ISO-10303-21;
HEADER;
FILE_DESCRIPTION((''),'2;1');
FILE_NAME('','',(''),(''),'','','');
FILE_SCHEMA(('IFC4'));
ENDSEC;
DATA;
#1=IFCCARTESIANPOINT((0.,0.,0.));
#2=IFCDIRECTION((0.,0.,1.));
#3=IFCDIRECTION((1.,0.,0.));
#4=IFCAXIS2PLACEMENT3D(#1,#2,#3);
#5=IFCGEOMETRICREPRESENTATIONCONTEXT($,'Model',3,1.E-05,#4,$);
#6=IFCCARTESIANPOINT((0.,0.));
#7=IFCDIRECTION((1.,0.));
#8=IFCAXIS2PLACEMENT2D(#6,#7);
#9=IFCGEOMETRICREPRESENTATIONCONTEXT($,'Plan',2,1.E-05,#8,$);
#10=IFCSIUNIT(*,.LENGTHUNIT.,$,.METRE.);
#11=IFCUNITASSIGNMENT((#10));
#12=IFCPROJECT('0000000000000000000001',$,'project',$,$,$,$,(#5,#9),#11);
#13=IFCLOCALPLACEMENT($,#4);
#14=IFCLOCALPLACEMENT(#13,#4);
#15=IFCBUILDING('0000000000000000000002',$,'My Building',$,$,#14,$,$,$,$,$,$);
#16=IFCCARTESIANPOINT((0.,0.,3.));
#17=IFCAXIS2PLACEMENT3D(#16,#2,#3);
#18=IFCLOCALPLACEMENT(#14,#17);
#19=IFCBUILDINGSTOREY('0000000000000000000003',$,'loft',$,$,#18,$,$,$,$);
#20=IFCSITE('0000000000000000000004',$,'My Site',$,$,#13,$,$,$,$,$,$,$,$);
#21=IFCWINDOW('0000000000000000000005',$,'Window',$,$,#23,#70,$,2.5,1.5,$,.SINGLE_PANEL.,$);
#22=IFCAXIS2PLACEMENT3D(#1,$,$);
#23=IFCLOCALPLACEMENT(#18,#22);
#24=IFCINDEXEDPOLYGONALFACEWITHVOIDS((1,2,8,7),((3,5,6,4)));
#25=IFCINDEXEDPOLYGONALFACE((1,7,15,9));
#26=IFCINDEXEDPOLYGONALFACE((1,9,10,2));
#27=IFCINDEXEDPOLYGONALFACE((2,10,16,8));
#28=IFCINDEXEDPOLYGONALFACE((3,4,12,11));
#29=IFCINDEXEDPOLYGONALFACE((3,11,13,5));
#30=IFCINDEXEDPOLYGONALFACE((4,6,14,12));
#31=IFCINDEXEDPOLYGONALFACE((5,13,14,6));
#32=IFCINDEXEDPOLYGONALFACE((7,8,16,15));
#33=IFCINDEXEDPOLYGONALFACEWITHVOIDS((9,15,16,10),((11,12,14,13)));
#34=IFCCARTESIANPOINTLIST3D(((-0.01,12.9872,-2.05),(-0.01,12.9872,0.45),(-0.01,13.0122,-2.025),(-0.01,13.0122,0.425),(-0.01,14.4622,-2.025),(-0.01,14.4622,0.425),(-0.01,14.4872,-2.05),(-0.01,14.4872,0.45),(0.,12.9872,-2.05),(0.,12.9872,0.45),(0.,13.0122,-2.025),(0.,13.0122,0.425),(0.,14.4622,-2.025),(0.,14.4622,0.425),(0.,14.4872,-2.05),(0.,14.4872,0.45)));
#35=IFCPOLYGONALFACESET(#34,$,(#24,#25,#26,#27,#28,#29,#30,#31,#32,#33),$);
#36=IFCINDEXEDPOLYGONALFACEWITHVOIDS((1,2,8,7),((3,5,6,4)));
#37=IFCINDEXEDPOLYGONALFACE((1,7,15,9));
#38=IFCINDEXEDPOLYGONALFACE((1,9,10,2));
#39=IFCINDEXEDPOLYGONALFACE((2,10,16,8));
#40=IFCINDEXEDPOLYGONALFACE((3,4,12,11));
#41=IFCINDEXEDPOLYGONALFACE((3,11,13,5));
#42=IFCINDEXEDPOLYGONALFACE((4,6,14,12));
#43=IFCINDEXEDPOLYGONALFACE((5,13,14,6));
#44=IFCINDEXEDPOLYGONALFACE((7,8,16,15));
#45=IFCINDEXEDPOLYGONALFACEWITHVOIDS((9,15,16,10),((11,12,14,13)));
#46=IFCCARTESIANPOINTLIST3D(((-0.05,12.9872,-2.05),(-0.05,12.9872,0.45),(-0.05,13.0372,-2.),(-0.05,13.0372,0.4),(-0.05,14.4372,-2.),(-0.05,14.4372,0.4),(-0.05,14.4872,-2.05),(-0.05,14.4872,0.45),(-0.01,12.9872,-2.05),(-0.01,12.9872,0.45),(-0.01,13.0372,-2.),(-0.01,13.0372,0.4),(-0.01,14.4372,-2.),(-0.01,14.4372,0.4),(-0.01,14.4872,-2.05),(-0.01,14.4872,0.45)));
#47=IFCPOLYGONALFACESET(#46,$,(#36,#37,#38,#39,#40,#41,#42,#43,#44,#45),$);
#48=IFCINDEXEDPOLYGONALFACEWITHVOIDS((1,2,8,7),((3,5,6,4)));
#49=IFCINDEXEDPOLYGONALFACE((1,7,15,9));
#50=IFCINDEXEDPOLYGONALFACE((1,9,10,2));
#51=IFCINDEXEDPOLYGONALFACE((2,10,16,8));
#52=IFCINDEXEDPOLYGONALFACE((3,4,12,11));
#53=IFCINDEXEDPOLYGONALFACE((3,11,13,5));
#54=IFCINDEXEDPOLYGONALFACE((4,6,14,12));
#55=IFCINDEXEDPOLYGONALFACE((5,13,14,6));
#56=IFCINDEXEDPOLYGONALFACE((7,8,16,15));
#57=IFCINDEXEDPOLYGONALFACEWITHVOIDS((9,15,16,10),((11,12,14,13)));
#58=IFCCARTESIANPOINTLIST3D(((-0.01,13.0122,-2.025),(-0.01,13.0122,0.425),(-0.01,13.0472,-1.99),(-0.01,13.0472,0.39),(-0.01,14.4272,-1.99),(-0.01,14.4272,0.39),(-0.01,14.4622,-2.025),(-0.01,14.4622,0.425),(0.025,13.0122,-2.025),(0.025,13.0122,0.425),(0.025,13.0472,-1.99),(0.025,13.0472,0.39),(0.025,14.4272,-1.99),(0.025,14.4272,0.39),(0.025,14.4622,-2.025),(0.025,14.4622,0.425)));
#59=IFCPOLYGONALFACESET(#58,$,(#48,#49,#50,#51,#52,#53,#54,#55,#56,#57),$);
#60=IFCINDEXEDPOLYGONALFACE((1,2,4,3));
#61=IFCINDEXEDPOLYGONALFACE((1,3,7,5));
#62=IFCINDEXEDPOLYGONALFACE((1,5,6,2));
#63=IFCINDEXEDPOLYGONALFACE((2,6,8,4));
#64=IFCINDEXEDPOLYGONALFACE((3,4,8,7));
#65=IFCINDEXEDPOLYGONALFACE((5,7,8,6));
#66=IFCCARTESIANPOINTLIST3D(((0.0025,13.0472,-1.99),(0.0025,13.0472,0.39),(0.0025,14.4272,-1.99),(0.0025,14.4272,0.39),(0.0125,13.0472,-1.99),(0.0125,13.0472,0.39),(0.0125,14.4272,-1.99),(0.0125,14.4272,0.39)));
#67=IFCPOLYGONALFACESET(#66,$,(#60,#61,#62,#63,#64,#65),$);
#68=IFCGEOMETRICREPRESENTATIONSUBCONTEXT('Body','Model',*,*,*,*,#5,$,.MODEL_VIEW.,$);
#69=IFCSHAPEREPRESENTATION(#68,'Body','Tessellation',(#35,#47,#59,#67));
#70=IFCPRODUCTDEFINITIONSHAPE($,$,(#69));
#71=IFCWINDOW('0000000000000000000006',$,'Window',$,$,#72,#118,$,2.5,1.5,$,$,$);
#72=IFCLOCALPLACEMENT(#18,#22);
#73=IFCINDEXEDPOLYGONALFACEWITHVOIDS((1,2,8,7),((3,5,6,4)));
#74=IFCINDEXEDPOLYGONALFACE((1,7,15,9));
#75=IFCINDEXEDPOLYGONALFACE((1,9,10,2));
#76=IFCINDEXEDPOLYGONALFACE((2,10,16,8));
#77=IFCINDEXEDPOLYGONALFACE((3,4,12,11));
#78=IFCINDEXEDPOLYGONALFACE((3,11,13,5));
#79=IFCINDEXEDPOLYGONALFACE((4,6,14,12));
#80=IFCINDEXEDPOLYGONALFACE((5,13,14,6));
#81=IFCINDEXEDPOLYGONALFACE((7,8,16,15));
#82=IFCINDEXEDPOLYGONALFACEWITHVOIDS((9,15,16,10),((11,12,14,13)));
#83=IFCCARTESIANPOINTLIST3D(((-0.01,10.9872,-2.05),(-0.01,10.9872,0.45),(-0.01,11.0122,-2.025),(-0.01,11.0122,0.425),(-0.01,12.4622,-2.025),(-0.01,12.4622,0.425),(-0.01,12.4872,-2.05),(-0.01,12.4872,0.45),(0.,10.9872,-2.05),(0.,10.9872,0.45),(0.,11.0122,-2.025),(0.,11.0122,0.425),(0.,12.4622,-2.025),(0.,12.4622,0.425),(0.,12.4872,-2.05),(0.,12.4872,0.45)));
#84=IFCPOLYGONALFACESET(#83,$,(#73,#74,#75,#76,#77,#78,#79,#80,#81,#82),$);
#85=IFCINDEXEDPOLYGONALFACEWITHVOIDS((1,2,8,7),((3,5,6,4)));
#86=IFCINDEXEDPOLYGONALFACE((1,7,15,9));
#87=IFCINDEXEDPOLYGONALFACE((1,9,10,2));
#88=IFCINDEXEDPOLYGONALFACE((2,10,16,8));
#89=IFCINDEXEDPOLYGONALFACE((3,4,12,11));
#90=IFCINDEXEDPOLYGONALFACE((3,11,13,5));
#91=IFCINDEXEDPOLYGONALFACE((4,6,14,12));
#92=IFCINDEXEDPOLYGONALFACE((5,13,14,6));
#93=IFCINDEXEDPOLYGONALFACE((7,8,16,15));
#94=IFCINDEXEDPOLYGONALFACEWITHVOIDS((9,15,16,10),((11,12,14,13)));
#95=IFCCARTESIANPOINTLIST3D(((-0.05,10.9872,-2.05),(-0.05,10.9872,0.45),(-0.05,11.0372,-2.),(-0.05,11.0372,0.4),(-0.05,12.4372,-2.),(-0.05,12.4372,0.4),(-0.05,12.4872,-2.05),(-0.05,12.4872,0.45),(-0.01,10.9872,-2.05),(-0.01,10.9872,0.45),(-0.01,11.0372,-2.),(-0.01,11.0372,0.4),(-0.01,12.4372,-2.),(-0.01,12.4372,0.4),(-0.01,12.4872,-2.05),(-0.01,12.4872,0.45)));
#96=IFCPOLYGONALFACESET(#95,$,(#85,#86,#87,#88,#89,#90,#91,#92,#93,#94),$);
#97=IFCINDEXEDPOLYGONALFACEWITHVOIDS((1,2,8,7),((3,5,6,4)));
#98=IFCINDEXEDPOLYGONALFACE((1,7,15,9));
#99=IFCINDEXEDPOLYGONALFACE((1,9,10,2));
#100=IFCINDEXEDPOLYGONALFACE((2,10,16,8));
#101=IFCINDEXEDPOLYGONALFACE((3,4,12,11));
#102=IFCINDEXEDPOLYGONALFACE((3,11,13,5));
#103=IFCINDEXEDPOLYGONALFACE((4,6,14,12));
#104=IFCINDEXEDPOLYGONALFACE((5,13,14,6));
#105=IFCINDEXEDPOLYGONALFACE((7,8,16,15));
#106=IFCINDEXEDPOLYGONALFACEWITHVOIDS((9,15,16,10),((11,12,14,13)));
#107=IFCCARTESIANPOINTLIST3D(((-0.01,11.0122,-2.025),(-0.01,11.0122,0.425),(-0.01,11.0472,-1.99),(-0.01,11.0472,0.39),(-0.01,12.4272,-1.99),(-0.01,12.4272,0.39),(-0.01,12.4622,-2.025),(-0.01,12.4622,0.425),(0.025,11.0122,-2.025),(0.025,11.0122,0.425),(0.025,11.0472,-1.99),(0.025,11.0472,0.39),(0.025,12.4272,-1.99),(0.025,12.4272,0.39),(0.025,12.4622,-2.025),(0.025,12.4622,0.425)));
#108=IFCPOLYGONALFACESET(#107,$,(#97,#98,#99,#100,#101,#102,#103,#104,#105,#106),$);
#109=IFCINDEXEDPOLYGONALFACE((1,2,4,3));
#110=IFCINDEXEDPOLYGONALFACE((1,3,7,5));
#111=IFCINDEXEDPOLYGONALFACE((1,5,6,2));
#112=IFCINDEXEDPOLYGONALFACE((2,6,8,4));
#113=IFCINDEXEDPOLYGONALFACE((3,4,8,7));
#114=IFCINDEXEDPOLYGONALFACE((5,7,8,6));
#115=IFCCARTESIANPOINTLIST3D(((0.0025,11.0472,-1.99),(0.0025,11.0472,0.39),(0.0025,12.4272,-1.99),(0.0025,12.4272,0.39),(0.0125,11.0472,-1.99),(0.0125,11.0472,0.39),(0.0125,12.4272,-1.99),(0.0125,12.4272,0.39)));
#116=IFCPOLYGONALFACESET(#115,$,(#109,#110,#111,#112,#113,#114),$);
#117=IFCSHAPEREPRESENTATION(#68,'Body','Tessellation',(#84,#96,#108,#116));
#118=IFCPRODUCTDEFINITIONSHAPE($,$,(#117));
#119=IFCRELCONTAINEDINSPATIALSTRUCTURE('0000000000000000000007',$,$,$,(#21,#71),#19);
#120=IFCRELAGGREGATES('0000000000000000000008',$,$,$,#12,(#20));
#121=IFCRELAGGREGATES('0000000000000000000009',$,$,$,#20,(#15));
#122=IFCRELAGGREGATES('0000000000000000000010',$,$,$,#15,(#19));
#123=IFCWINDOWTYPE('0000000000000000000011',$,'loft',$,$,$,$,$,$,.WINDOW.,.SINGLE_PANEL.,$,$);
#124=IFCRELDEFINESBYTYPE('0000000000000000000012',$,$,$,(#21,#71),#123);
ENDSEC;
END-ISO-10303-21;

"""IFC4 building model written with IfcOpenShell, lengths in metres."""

from ifc_helpers import new_model, entity, si_unit, frame, origin_with_axes, origin_2d_with_axis, place, context, subcontext, project, spatial, line, indexed_curve, outline, extrude, shape, source, transform, mapped, type_object, type_shapes, element, save


model = new_model("IFC4")

# Units and contexts
model_context = context("Model", 3, precision=1e-05, world=origin_with_axes())
plan_context = context("Plan", 2, precision=1e-05, world=origin_2d_with_axis())
body_context_1 = subcontext(model_context, "Body", "Model", "MODEL_VIEW")
body_context_2 = subcontext(plan_context, "Body", "Plan", "PLAN_VIEW")
ifc_project = project(units=[si_unit("LENGTHUNIT", "METRE")], contexts=[model_context, plan_context])

# Site, building, storey
site_placement = place(None, origin_with_axes())
site = spatial("IfcSite", under=ifc_project, at=site_placement, Name="My Site")
building_placement = place(site_placement, origin_with_axes())
building = spatial("IfcBuilding", under=site, at=building_placement, Name="My Building")
storey_placement = place(building_placement, frame((0.0, 0.0, 3.0), z_axis=(0.0, 0.0, 1.0), x_axis=(1.0, 0.0, 0.0)))
storey = spatial("IfcBuildingStorey", under=building, at=storey_placement, Name="loft")

# Shared definitions
window_type = type_object("IfcWindowType", Name="loft", PartitioningType="SINGLE_PANEL", PredefinedType="WINDOW")
shared_shape_1 = source(origin_with_axes(), body_context_1, "Body", "SweptSolid", [
    extrude(outline(indexed_curve([(0.0, 0.0), (1.5, 0.0), (1.5, 2.5), (0.0, 2.5)], segments=[line(1, 2, 3, 4, 1)]), holes=[indexed_curve([(0.025, 0.025), (1.475, 0.025), (1.475, 2.475), (0.025, 2.475)], segments=[line(1, 2, 3, 4, 1)])]), frame((0.0, 0.09, 0.0), z_axis=(0.0, -1.0, 0.0), x_axis=(1.0, 0.0, 0.0)), (0.0, 0.0, -1.0), 0.01),
    extrude(outline(indexed_curve([(0.0, 0.0), (1.5, 0.0), (1.5, 2.5), (0.0, 2.5)], segments=[line(1, 2, 3, 4, 1)]), holes=[indexed_curve([(0.05, 0.05), (1.45, 0.05), (1.45, 2.45), (0.05, 2.45)], segments=[line(1, 2, 3, 4, 1)])]), frame((0.0, 0.05, 0.0), z_axis=(0.0, -1.0, 0.0), x_axis=(1.0, 0.0, 0.0)), (0.0, 0.0, -1.0), 0.04),
    extrude(outline(indexed_curve([(0.0, 0.0), (1.45, 0.0), (1.45, 2.45), (0.0, 2.45)], segments=[line(1, 2, 3, 4, 1)]), holes=[indexed_curve([(0.035, 0.035), (1.415, 0.035), (1.415, 2.415), (0.035, 2.415)], segments=[line(1, 2, 3, 4, 1)])]), frame((0.025, 0.09, 0.025), z_axis=(0.0, -1.0, 0.0), x_axis=(1.0, 0.0, 0.0)), (0.0, 0.0, -1.0), 0.035),
    extrude(outline(indexed_curve([(0.035, 0.035), (1.415, 0.035), (1.415, 2.415), (0.035, 2.415)], segments=[line(1, 2, 3, 4, 1)])), frame((0.025, 0.1025, 0.025), z_axis=(0.0, -1.0, 0.0), x_axis=(1.0, 0.0, 0.0)), (0.0, 0.0, -1.0), 0.01),
])
shared_shape_2 = source(origin_with_axes(), body_context_2, "Body", "Curve2D", [
    entity("IfcIndexedPolyCurve", entity("IfcCartesianPointList2D", [[0.05, 0.05], [1.45, 0.05]])),
    entity("IfcIndexedPolyCurve", entity("IfcCartesianPointList2D", [[0.0, 0.1], [0.025, 0.1], [0.025, 0.09], [0.05, 0.09], [0.05, 0.05], [0.0, 0.05]]), [entity("IfcLineIndex", [1, 2, 3, 4, 5, 6, 1])]),
    entity("IfcIndexedPolyCurve", entity("IfcCartesianPointList2D", [[1.5, 0.1], [1.475, 0.1], [1.475, 0.09], [1.45, 0.09], [1.45, 0.05], [1.5, 0.05]]), [entity("IfcLineIndex", [1, 2, 3, 4, 5, 6, 1])]),
    entity("IfcIndexedPolyCurve", entity("IfcCartesianPointList2D", [[0.025, 0.09], [0.06, 0.09], [0.06, 0.125], [0.025, 0.125]]), [entity("IfcLineIndex", [1, 2, 3, 4, 1])]),
    entity("IfcIndexedPolyCurve", entity("IfcCartesianPointList2D", [[1.475, 0.09], [1.44, 0.09], [1.44, 0.125], [1.475, 0.125]]), [entity("IfcLineIndex", [1, 2, 3, 4, 1])]),
    entity("IfcIndexedPolyCurve", entity("IfcCartesianPointList2D", [[0.06, 0.09], [1.44, 0.09]])),
    entity("IfcIndexedPolyCurve", entity("IfcCartesianPointList2D", [[0.06, 0.125], [1.44, 0.125]])),
    entity("IfcIndexedPolyCurve", entity("IfcCartesianPointList2D", [[0.06, 0.1075], [1.44, 0.1075]])),
])
type_shapes(window_type, [shared_shape_1, shared_shape_2])

# Windows
window_1_placement = place(storey_placement, frame((-0.1, 14.4872, -2.05), z_axis=(0.0, 0.0, 1.0), x_axis=(0.0, -1.0, 0.0)))
element("IfcWindow", 1, at=window_1_placement, inside=storey, type_object=window_type, Name="Window", OverallHeight=2.5, OverallWidth=1.5, PartitioningType="SINGLE_PANEL", shapes=[
    shape(body_context_1, "Body", "MappedRepresentation", [mapped(shared_shape_1, transform((0.0, 0.0, 0.0), x_axis=(1.0, 0.0, 0.0), y_axis=(0.0, 1.0, 0.0), z_axis=(0.0, 0.0, 1.0), scale=1.0))]),
    shape(body_context_2, "Body", "MappedRepresentation", [mapped(shared_shape_2, transform((0.0, 0.0, 0.0), x_axis=(1.0, 0.0, 0.0), y_axis=(0.0, 1.0, 0.0), z_axis=(0.0, 0.0, 1.0), scale=1.0))]),
])
window_2_placement = place(storey_placement, frame((-0.1, 12.4872, -2.05), z_axis=(0.0, 0.0, 1.0), x_axis=(0.0, -1.0, 0.0)))
element("IfcWindow", 2, at=window_2_placement, inside=storey, type_object=window_type, Name="Window", OverallHeight=2.5, OverallWidth=1.5, shapes=[
    shape(body_context_1, "Body", "MappedRepresentation", [mapped(shared_shape_1, transform((0.0, 0.0, 0.0), x_axis=(1.0, 0.0, 0.0), y_axis=(0.0, 1.0, 0.0), z_axis=(0.0, 0.0, 1.0), scale=1.0))]),
    shape(body_context_2, "Body", "MappedRepresentation", [mapped(shared_shape_2, transform((0.0, 0.0, 0.0), x_axis=(1.0, 0.0, 0.0), y_axis=(0.0, 1.0, 0.0), z_axis=(0.0, 0.0, 1.0), scale=1.0))]),
])

save(model, "model.ifc")
